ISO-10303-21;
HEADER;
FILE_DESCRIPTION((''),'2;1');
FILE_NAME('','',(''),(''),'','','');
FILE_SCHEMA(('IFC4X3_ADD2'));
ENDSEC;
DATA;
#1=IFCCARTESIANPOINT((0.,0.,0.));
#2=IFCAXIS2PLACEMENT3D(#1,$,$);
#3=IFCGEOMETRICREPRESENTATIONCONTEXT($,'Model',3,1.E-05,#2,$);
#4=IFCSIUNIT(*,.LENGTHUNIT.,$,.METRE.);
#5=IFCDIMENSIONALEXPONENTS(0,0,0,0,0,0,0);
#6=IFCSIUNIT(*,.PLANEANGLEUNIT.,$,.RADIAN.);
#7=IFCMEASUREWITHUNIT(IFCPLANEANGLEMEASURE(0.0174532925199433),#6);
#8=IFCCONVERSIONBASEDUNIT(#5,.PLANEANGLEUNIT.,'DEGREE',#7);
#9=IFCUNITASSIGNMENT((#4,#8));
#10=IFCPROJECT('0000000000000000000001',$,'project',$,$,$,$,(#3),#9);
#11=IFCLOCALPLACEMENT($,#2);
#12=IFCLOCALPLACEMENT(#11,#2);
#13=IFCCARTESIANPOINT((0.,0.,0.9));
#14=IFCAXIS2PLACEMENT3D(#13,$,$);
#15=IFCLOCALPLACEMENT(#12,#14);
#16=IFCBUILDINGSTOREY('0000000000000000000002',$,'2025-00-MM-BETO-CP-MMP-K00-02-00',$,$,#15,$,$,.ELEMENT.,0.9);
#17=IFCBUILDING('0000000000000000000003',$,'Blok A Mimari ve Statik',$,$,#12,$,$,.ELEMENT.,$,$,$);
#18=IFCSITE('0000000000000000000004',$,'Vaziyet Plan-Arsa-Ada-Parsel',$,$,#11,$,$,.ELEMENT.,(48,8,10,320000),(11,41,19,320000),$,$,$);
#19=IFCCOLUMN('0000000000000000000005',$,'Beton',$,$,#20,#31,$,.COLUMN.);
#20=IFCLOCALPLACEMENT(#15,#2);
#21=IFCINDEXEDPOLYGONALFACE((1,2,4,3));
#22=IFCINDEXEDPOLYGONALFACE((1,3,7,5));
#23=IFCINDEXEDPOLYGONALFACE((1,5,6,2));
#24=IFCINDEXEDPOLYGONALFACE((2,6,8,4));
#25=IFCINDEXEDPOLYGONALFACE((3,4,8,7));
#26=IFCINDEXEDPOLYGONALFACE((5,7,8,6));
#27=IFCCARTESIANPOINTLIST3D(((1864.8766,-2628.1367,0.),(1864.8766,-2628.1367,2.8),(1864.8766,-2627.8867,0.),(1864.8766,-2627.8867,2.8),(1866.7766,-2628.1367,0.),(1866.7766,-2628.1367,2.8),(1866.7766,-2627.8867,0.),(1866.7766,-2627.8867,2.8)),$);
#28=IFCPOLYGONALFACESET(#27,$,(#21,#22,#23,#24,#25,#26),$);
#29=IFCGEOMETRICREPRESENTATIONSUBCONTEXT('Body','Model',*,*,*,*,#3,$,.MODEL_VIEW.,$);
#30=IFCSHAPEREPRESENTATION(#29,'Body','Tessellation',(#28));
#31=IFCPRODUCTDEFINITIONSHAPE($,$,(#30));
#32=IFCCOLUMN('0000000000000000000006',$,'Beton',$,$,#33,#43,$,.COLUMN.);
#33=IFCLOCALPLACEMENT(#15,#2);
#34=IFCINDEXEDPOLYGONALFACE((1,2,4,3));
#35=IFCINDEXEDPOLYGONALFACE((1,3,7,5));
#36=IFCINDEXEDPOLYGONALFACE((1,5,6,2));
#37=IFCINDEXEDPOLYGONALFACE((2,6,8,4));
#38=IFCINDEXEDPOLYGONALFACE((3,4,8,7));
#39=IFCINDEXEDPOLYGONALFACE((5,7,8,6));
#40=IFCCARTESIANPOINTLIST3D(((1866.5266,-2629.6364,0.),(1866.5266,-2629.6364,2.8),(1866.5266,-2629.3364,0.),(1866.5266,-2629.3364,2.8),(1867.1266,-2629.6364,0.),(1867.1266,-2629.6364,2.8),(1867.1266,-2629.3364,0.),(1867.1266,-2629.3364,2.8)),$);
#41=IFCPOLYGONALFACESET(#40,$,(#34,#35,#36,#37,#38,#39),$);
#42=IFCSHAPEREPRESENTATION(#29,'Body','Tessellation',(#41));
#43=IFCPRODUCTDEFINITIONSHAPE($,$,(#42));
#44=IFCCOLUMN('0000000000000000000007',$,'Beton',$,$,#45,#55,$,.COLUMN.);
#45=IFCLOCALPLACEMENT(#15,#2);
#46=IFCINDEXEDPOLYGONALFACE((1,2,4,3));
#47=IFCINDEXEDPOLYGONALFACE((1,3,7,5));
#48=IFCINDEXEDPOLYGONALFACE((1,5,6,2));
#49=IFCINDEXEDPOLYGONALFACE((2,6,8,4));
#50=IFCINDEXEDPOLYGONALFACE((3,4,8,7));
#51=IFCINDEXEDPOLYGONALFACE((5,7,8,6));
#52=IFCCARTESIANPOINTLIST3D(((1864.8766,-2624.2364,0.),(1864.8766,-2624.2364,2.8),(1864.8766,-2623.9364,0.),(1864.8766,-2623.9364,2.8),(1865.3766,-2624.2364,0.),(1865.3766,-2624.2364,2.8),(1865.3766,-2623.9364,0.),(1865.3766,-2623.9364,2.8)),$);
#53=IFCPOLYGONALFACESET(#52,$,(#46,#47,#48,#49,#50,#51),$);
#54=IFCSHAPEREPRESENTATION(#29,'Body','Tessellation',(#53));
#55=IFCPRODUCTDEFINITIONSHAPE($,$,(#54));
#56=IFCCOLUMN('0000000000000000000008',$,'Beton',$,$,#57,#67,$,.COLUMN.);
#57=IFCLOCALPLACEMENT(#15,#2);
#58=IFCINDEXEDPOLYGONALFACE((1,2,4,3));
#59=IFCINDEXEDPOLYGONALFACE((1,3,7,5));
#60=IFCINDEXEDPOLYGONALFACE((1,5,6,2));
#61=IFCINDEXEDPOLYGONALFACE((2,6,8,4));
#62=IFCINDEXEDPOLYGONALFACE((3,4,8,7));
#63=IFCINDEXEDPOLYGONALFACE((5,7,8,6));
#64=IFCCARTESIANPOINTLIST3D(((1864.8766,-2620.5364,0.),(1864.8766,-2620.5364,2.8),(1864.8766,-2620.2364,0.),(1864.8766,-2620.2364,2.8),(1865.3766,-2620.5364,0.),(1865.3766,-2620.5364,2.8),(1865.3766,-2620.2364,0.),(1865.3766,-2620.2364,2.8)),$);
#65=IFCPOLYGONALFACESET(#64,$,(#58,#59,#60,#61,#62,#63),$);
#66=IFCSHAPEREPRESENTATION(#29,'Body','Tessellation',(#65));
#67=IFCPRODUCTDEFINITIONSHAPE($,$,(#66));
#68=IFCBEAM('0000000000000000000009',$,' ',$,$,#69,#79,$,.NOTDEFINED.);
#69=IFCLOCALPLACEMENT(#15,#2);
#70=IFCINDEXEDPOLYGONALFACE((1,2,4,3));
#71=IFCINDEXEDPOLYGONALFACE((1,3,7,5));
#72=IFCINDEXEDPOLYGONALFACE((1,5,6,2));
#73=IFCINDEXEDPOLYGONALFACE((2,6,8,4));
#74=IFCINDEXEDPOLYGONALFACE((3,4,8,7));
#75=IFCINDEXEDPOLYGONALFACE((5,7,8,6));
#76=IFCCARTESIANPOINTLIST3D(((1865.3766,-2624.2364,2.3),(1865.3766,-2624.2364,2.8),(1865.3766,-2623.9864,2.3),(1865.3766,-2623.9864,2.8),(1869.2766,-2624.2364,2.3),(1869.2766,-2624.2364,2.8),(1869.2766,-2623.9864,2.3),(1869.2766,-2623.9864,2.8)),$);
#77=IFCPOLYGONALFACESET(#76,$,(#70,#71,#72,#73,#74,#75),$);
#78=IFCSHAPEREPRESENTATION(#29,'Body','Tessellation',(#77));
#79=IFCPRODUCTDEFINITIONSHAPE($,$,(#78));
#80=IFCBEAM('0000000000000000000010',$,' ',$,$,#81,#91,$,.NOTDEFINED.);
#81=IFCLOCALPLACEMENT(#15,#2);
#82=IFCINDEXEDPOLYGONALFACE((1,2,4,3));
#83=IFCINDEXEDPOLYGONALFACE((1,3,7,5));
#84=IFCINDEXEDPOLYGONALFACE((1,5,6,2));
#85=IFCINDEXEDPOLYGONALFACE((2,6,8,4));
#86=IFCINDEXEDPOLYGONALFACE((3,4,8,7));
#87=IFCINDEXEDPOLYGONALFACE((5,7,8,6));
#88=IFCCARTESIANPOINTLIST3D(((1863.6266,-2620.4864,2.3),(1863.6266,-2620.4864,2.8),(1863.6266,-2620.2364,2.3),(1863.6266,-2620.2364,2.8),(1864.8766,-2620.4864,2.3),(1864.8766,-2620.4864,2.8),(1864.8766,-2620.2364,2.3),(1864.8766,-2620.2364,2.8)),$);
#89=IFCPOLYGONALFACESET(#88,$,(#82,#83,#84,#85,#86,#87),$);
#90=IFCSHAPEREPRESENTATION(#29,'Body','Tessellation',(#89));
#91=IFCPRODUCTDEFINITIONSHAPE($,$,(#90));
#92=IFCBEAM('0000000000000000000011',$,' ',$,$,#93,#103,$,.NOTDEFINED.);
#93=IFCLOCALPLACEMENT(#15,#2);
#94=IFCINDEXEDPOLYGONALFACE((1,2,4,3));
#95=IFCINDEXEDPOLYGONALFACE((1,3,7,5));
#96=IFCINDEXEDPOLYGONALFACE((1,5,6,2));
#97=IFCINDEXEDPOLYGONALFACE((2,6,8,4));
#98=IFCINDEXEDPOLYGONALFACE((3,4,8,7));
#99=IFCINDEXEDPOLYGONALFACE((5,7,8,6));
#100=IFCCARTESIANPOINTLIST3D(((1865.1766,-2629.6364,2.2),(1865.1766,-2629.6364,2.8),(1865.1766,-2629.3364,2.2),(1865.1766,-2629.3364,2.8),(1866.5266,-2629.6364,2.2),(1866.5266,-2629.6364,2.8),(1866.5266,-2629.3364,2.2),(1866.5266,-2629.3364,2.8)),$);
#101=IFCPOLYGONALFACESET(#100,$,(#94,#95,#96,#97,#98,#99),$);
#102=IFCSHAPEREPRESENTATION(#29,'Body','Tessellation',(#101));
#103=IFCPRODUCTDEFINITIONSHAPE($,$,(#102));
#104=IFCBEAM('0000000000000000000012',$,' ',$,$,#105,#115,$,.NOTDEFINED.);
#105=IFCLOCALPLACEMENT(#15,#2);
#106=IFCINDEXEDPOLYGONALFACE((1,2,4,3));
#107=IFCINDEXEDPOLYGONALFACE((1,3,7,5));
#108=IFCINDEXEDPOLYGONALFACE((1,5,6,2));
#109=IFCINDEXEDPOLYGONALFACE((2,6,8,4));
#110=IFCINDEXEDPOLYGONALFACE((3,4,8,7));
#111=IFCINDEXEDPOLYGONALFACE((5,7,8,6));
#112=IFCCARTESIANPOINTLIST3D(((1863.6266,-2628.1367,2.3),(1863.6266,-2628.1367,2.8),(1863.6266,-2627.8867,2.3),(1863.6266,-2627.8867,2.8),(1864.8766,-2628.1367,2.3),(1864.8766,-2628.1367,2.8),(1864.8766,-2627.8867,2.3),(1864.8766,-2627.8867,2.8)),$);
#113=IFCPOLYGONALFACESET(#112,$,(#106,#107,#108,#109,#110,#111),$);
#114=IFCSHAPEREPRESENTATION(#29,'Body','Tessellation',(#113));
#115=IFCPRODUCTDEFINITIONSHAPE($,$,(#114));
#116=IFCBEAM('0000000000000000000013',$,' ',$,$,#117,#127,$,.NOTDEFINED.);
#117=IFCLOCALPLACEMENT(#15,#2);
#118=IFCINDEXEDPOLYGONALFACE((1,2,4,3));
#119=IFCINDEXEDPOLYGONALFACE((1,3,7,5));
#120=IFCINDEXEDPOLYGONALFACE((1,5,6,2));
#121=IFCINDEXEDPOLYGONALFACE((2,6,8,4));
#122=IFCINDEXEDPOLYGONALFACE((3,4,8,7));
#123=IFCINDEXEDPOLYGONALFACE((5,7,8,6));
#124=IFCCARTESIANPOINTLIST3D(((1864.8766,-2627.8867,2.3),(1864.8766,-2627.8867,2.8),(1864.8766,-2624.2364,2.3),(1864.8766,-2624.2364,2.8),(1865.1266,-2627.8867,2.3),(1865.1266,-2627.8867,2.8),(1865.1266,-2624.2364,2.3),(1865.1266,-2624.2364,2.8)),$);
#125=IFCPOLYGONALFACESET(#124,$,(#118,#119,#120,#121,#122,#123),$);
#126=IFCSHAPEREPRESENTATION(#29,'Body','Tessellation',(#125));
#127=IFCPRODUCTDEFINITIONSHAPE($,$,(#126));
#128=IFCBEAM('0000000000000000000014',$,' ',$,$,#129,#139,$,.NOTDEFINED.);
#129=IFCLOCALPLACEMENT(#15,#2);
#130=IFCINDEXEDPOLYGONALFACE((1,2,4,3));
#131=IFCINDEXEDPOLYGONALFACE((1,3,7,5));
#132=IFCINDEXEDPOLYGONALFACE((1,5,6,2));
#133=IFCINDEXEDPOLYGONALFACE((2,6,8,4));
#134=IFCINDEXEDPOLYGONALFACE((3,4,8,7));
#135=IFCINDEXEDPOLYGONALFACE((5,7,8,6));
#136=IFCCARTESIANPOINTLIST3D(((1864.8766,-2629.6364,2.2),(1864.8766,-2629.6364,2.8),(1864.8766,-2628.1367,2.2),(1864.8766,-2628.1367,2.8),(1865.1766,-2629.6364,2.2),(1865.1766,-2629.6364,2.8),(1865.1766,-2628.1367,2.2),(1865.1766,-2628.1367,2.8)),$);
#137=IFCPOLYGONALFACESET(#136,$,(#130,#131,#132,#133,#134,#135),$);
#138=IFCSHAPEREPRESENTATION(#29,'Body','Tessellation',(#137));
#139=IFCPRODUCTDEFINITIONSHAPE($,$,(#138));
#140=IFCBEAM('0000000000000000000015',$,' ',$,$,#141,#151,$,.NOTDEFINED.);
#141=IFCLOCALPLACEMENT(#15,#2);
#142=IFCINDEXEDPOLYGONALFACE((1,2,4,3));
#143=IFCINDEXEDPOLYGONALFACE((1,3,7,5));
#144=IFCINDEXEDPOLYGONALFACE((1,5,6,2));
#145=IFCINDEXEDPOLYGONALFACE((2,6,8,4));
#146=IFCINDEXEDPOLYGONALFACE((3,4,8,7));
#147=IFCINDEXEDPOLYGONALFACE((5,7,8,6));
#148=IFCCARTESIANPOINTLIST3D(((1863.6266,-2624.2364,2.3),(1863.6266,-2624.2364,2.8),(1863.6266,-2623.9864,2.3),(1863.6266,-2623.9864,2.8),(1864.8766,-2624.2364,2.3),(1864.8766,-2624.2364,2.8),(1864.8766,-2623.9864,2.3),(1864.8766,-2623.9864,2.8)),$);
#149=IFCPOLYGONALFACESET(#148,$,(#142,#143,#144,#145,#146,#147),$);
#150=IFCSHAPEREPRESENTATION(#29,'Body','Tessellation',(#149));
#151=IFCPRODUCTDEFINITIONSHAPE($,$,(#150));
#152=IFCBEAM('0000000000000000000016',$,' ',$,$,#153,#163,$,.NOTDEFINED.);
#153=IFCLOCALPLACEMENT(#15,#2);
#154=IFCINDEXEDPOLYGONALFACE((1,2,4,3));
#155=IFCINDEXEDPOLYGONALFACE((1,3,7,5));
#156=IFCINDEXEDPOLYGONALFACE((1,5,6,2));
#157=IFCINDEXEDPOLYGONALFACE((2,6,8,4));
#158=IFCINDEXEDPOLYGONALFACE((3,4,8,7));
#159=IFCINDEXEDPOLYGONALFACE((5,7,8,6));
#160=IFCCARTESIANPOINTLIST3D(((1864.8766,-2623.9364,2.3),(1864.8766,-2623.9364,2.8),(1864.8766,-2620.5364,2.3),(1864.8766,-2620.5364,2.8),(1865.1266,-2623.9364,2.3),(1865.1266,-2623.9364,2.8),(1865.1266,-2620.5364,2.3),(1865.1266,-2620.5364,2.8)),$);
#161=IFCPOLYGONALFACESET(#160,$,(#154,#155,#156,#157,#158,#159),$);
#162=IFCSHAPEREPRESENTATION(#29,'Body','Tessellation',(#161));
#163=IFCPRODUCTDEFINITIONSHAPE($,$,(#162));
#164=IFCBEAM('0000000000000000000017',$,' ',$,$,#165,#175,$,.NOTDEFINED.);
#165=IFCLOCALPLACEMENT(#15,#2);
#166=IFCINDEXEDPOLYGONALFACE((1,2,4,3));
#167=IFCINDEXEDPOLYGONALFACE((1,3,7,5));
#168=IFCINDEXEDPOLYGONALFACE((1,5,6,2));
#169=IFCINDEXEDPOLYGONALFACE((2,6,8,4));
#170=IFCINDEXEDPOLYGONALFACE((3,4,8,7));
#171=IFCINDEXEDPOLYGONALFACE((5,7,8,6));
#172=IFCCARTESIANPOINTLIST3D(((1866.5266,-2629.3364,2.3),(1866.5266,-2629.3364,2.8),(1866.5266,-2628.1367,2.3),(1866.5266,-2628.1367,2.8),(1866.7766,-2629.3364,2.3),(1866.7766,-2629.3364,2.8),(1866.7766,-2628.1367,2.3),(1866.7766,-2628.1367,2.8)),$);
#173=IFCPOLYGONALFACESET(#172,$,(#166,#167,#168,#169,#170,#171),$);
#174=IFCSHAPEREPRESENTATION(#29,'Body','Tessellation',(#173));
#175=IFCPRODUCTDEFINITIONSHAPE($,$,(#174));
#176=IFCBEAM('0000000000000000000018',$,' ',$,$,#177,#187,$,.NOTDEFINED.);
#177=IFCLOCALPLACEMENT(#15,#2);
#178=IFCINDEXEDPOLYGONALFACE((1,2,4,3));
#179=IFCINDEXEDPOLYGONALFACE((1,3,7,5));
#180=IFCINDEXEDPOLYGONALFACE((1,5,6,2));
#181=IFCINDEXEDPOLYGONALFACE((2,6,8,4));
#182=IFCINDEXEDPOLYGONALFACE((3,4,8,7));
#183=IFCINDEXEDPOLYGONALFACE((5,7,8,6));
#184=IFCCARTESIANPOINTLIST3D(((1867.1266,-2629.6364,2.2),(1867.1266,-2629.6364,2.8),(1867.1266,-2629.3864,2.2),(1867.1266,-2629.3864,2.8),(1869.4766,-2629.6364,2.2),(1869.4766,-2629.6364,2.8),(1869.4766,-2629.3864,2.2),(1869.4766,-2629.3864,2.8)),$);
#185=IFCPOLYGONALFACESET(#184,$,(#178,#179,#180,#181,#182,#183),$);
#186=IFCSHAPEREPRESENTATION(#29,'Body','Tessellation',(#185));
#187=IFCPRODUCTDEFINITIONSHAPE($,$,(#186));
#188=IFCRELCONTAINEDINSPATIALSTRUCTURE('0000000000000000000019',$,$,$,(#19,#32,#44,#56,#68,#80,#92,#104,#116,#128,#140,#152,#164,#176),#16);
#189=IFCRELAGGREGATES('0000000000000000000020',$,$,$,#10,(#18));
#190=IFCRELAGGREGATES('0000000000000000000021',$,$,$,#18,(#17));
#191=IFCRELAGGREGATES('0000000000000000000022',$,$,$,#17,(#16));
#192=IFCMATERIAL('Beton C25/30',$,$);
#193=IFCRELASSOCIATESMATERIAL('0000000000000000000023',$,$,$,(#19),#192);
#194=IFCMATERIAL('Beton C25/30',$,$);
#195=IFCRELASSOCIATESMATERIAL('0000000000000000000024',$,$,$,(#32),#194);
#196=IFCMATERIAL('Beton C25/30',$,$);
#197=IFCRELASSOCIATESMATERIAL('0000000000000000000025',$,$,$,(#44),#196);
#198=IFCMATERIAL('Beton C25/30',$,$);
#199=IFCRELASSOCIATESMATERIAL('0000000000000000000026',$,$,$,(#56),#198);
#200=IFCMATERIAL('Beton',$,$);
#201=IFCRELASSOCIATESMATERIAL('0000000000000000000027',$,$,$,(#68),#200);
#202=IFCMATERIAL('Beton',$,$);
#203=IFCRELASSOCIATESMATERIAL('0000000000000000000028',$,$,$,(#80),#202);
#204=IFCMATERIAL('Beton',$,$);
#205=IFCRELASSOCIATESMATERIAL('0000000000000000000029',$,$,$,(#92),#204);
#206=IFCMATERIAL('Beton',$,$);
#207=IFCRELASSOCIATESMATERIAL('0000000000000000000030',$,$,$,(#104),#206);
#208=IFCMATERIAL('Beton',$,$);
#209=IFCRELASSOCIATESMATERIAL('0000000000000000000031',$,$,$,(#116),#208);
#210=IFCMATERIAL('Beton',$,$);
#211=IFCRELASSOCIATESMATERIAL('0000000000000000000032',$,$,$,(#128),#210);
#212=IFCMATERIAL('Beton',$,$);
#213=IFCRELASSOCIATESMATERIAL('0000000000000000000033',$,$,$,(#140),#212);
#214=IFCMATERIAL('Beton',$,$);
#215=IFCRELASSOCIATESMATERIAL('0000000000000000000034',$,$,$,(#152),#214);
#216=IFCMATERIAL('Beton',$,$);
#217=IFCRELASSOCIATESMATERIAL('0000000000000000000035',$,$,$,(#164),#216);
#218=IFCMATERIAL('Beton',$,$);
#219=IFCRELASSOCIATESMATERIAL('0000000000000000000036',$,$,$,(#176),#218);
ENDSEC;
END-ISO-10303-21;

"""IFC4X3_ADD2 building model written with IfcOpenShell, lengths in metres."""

from ifc_helpers import new_model, entity, si_unit, converted_unit, frame, frame_2d, origin, origin_with_axes, place, context, subcontext, project, spatial, polyline, rectangle, outline, extrude, material, element, save


model = new_model("IFC4X3_ADD2")

# Units and contexts
model_context = context("Model", 3, precision=1e-05, world=origin())
body_context = subcontext(model_context, "Body", "Model", "MODEL_VIEW")
ifc_project = project(units=[si_unit("LENGTHUNIT", "METRE"), converted_unit("PLANEANGLEUNIT", "DEGREE", entity("IfcPlaneAngleMeasure", 0.0174532925199433), si_unit("PLANEANGLEUNIT", "RADIAN"), dimensions=[0, 0, 0, 0, 0, 0, 0])], contexts=[model_context])

# Site, building, storey
site_placement = place(None, origin())
site = spatial("IfcSite", under=ifc_project, at=site_placement, Name="Vaziyet Plan-Arsa-Ada-Parsel", CompositionType="ELEMENT", RefLatitude=(48, 8, 10, 320000), RefLongitude=(11, 41, 19, 320000))
building_placement = place(site_placement, origin())
building = spatial("IfcBuilding", under=site, at=building_placement, Name="Blok A Mimari ve Statik", CompositionType="ELEMENT")
storey_placement = place(building_placement, frame((0.0, 0.0, 0.9)))
storey = spatial("IfcBuildingStorey", under=building, at=storey_placement, Name="2025-00-MM-BETO-CP-MMP-K00-02-00", CompositionType="ELEMENT", Elevation=0.9)

# Columns
ifc_material_1 = material(Name="Beton C25/30")
column_1_placement = place(storey_placement, frame((1864.8766, -2628.1367, 0.0)))
element("IfcColumn", 1, at=column_1_placement, inside=storey, material=ifc_material_1, Name="Beton", PredefinedType="COLUMN", context=body_context, shape_type="SweptSolid", body=[
    extrude(outline(polyline([(1.9, 0.25), (0.0, 0.25), (0.0, 0.0), (1.9, 0.0), (1.9, 0.25)])), origin_with_axes(), (0.0, 0.0, 1.0), 2.8),
])
ifc_material_2 = material(Name="Beton C25/30")
column_2_placement = place(storey_placement, frame((1866.5266, -2629.6364, 0.0)))
element("IfcColumn", 2, at=column_2_placement, inside=storey, material=ifc_material_2, Name="Beton", PredefinedType="COLUMN", context=body_context, shape_type="SweptSolid", body=[
    extrude(outline(polyline([(0.0, 0.3), (0.0, 0.0), (0.6, 0.0), (0.6, 0.3), (0.0, 0.3)])), origin_with_axes(), (0.0, 0.0, 1.0), 2.8),
])
ifc_material_3 = material(Name="Beton C25/30")
column_3_placement = place(storey_placement, frame((1864.8766, -2624.2364, 0.0)))
element("IfcColumn", 3, at=column_3_placement, inside=storey, material=ifc_material_3, Name="Beton", PredefinedType="COLUMN", context=body_context, shape_type="SweptSolid", body=[
    extrude(outline(polyline([(0.0, 0.0), (0.5, 0.0), (0.5, 0.3), (0.0, 0.3), (0.0, 0.0)])), origin_with_axes(), (0.0, 0.0, 1.0), 2.8),
])
ifc_material_4 = material(Name="Beton C25/30")
column_4_placement = place(storey_placement, frame((1864.8766, -2620.5364, 0.0)))
element("IfcColumn", 4, at=column_4_placement, inside=storey, material=ifc_material_4, Name="Beton", PredefinedType="COLUMN", context=body_context, shape_type="SweptSolid", body=[
    extrude(outline(polyline([(0.0, 0.0), (0.5, 0.0), (0.5, 0.3), (0.0, 0.3), (0.0, 0.0)])), origin_with_axes(), (0.0, 0.0, 1.0), 2.8),
])

# Beams
ifc_material_5 = material(Name="Beton")
beam_1_placement = place(storey_placement, frame((1865.3766, -2624.2364, 2.3), z_axis=(0.0, 0.0, 1.0), x_axis=(1.0, 0.0, 0.0)))
element("IfcBeam", 5, at=beam_1_placement, inside=storey, material=ifc_material_5, Name=" ", PredefinedType="NOTDEFINED", context=body_context, shape_type="SweptSolid", body=[
    extrude(rectangle(XDim=0.25, YDim=0.5, at=frame_2d((0.125, 0.25), x_axis=(1.0, 0.0))), frame((0.0, 0.0, 0.0), z_axis=(1.0, 0.0, 0.0), x_axis=(0.0, 1.0, 0.0)), (0.0, 0.0, 1.0), 3.9),
])
ifc_material_6 = material(Name="Beton")
beam_2_placement = place(storey_placement, frame((1863.6266, -2620.4864, 2.3)))
element("IfcBeam", 6, at=beam_2_placement, inside=storey, material=ifc_material_6, Name=" ", PredefinedType="NOTDEFINED", context=body_context, shape_type="SweptSolid", body=[
    extrude(rectangle(XDim=0.25, YDim=0.5, at=frame_2d((0.125, 0.25), x_axis=(1.0, 0.0))), frame((0.0, 0.0, 0.0), z_axis=(1.0, 0.0, 0.0), x_axis=(0.0, 1.0, 0.0)), (0.0, 0.0, 1.0), 1.25),
])
ifc_material_7 = material(Name="Beton")
beam_3_placement = place(storey_placement, frame((1865.1766, -2629.6364, 2.2), z_axis=(0.0, 0.0, 1.0), x_axis=(1.0, 0.0, 0.0)))
element("IfcBeam", 7, at=beam_3_placement, inside=storey, material=ifc_material_7, Name=" ", PredefinedType="NOTDEFINED", context=body_context, shape_type="SweptSolid", body=[
    extrude(rectangle(XDim=0.3, YDim=0.6, at=frame_2d((0.15, 0.3), x_axis=(1.0, 0.0))), frame((0.0, 0.0, 0.0), z_axis=(1.0, 0.0, 0.0), x_axis=(0.0, 1.0, 0.0)), (0.0, 0.0, 1.0), 1.35),
])
ifc_material_8 = material(Name="Beton")
beam_4_placement = place(storey_placement, frame((1863.6266, -2628.1367, 2.3), z_axis=(0.0, 0.0, 1.0), x_axis=(1.0, 0.000001, 0.0)))
element("IfcBeam", 8, at=beam_4_placement, inside=storey, material=ifc_material_8, Name=" ", PredefinedType="NOTDEFINED", context=body_context, shape_type="SweptSolid", body=[
    extrude(rectangle(XDim=0.25, YDim=0.5, at=frame_2d((0.125, 0.25), x_axis=(1.0, 0.0))), frame((0.0, 0.0, 0.0), z_axis=(1.0, 0.0, 0.0), x_axis=(0.0, 1.0, 0.0)), (0.0, 0.0, 1.0), 1.25),
])
ifc_material_9 = material(Name="Beton")
beam_5_placement = place(storey_placement, frame((1864.8766, -2624.2364, 2.3), z_axis=(0.0, 0.0, 1.0), x_axis=(0.0, -1.0, 0.0)))
element("IfcBeam", 9, at=beam_5_placement, inside=storey, material=ifc_material_9, Name=" ", PredefinedType="NOTDEFINED", context=body_context, shape_type="SweptSolid", body=[
    extrude(rectangle(XDim=0.25, YDim=0.5, at=frame_2d((0.125, 0.25), x_axis=(1.0, 0.0))), frame((0.0, 0.0, 0.0), z_axis=(1.0, 0.0, 0.0), x_axis=(0.0, 1.0, 0.0)), (0.0, 0.0, 1.0), 3.6503),
])
ifc_material_10 = material(Name="Beton")
beam_6_placement = place(storey_placement, frame((1864.8766, -2628.1367, 2.2), z_axis=(0.0, 0.0, 1.0), x_axis=(0.0, -1.0, 0.0)))
element("IfcBeam", 10, at=beam_6_placement, inside=storey, material=ifc_material_10, Name=" ", PredefinedType="NOTDEFINED", context=body_context, shape_type="SweptSolid", body=[
    extrude(rectangle(XDim=0.3, YDim=0.6, at=frame_2d((0.15, 0.3), x_axis=(1.0, 0.0))), frame((0.0, 0.0, 0.0), z_axis=(1.0, 0.0, 0.0), x_axis=(0.0, 1.0, 0.0)), (0.0, 0.0, 1.0), 1.4997),
])
ifc_material_11 = material(Name="Beton")
beam_7_placement = place(storey_placement, frame((1863.6266, -2624.2364, 2.3), z_axis=(0.0, 0.0, 1.0), x_axis=(1.0, 0.000002, 0.0)))
element("IfcBeam", 11, at=beam_7_placement, inside=storey, material=ifc_material_11, Name=" ", PredefinedType="NOTDEFINED", context=body_context, shape_type="SweptSolid", body=[
    extrude(rectangle(XDim=0.25, YDim=0.5, at=frame_2d((0.125, 0.25), x_axis=(1.0, 0.0))), frame((0.0, 0.0, 0.0), z_axis=(1.0, 0.0, 0.0), x_axis=(0.0, 1.0, 0.0)), (0.0, 0.0, 1.0), 1.25),
])
ifc_material_12 = material(Name="Beton")
beam_8_placement = place(storey_placement, frame((1864.8766, -2620.5364, 2.3), z_axis=(0.0, 0.0, 1.0), x_axis=(0.0, -1.0, 0.0)))
element("IfcBeam", 12, at=beam_8_placement, inside=storey, material=ifc_material_12, Name=" ", PredefinedType="NOTDEFINED", context=body_context, shape_type="SweptSolid", body=[
    extrude(rectangle(XDim=0.25, YDim=0.5, at=frame_2d((0.125, 0.25), x_axis=(1.0, 0.0))), frame((0.0, 0.0, 0.0), z_axis=(1.0, 0.0, 0.0), x_axis=(0.0, 1.0, 0.0)), (0.0, 0.0, 1.0), 3.4),
])
ifc_material_13 = material(Name="Beton")
beam_9_placement = place(storey_placement, frame((1866.5266, -2628.1367, 2.3), z_axis=(0.0, 0.0, 1.0), x_axis=(0.0, -1.0, 0.0)))
element("IfcBeam", 13, at=beam_9_placement, inside=storey, material=ifc_material_13, Name=" ", PredefinedType="NOTDEFINED", context=body_context, shape_type="SweptSolid", body=[
    extrude(rectangle(XDim=0.25, YDim=0.5, at=frame_2d((0.125, 0.25), x_axis=(1.0, 0.0))), frame((0.0, 0.0, 0.0), z_axis=(1.0, 0.0, 0.0), x_axis=(0.0, 1.0, 0.0)), (0.0, 0.0, 1.0), 1.1997),
])
ifc_material_14 = material(Name="Beton")
beam_10_placement = place(storey_placement, frame((1867.1266, -2629.6364, 2.2)))
element("IfcBeam", 14, at=beam_10_placement, inside=storey, material=ifc_material_14, Name=" ", PredefinedType="NOTDEFINED", context=body_context, shape_type="SweptSolid", body=[
    extrude(rectangle(XDim=0.25, YDim=0.6, at=frame_2d((0.125, 0.3), x_axis=(1.0, 0.0))), frame((0.0, 0.0, 0.0), z_axis=(1.0, 0.0, 0.0), x_axis=(0.0, 1.0, 0.0)), (0.0, 0.0, 1.0), 2.35),
])

save(model, "model.ifc")
